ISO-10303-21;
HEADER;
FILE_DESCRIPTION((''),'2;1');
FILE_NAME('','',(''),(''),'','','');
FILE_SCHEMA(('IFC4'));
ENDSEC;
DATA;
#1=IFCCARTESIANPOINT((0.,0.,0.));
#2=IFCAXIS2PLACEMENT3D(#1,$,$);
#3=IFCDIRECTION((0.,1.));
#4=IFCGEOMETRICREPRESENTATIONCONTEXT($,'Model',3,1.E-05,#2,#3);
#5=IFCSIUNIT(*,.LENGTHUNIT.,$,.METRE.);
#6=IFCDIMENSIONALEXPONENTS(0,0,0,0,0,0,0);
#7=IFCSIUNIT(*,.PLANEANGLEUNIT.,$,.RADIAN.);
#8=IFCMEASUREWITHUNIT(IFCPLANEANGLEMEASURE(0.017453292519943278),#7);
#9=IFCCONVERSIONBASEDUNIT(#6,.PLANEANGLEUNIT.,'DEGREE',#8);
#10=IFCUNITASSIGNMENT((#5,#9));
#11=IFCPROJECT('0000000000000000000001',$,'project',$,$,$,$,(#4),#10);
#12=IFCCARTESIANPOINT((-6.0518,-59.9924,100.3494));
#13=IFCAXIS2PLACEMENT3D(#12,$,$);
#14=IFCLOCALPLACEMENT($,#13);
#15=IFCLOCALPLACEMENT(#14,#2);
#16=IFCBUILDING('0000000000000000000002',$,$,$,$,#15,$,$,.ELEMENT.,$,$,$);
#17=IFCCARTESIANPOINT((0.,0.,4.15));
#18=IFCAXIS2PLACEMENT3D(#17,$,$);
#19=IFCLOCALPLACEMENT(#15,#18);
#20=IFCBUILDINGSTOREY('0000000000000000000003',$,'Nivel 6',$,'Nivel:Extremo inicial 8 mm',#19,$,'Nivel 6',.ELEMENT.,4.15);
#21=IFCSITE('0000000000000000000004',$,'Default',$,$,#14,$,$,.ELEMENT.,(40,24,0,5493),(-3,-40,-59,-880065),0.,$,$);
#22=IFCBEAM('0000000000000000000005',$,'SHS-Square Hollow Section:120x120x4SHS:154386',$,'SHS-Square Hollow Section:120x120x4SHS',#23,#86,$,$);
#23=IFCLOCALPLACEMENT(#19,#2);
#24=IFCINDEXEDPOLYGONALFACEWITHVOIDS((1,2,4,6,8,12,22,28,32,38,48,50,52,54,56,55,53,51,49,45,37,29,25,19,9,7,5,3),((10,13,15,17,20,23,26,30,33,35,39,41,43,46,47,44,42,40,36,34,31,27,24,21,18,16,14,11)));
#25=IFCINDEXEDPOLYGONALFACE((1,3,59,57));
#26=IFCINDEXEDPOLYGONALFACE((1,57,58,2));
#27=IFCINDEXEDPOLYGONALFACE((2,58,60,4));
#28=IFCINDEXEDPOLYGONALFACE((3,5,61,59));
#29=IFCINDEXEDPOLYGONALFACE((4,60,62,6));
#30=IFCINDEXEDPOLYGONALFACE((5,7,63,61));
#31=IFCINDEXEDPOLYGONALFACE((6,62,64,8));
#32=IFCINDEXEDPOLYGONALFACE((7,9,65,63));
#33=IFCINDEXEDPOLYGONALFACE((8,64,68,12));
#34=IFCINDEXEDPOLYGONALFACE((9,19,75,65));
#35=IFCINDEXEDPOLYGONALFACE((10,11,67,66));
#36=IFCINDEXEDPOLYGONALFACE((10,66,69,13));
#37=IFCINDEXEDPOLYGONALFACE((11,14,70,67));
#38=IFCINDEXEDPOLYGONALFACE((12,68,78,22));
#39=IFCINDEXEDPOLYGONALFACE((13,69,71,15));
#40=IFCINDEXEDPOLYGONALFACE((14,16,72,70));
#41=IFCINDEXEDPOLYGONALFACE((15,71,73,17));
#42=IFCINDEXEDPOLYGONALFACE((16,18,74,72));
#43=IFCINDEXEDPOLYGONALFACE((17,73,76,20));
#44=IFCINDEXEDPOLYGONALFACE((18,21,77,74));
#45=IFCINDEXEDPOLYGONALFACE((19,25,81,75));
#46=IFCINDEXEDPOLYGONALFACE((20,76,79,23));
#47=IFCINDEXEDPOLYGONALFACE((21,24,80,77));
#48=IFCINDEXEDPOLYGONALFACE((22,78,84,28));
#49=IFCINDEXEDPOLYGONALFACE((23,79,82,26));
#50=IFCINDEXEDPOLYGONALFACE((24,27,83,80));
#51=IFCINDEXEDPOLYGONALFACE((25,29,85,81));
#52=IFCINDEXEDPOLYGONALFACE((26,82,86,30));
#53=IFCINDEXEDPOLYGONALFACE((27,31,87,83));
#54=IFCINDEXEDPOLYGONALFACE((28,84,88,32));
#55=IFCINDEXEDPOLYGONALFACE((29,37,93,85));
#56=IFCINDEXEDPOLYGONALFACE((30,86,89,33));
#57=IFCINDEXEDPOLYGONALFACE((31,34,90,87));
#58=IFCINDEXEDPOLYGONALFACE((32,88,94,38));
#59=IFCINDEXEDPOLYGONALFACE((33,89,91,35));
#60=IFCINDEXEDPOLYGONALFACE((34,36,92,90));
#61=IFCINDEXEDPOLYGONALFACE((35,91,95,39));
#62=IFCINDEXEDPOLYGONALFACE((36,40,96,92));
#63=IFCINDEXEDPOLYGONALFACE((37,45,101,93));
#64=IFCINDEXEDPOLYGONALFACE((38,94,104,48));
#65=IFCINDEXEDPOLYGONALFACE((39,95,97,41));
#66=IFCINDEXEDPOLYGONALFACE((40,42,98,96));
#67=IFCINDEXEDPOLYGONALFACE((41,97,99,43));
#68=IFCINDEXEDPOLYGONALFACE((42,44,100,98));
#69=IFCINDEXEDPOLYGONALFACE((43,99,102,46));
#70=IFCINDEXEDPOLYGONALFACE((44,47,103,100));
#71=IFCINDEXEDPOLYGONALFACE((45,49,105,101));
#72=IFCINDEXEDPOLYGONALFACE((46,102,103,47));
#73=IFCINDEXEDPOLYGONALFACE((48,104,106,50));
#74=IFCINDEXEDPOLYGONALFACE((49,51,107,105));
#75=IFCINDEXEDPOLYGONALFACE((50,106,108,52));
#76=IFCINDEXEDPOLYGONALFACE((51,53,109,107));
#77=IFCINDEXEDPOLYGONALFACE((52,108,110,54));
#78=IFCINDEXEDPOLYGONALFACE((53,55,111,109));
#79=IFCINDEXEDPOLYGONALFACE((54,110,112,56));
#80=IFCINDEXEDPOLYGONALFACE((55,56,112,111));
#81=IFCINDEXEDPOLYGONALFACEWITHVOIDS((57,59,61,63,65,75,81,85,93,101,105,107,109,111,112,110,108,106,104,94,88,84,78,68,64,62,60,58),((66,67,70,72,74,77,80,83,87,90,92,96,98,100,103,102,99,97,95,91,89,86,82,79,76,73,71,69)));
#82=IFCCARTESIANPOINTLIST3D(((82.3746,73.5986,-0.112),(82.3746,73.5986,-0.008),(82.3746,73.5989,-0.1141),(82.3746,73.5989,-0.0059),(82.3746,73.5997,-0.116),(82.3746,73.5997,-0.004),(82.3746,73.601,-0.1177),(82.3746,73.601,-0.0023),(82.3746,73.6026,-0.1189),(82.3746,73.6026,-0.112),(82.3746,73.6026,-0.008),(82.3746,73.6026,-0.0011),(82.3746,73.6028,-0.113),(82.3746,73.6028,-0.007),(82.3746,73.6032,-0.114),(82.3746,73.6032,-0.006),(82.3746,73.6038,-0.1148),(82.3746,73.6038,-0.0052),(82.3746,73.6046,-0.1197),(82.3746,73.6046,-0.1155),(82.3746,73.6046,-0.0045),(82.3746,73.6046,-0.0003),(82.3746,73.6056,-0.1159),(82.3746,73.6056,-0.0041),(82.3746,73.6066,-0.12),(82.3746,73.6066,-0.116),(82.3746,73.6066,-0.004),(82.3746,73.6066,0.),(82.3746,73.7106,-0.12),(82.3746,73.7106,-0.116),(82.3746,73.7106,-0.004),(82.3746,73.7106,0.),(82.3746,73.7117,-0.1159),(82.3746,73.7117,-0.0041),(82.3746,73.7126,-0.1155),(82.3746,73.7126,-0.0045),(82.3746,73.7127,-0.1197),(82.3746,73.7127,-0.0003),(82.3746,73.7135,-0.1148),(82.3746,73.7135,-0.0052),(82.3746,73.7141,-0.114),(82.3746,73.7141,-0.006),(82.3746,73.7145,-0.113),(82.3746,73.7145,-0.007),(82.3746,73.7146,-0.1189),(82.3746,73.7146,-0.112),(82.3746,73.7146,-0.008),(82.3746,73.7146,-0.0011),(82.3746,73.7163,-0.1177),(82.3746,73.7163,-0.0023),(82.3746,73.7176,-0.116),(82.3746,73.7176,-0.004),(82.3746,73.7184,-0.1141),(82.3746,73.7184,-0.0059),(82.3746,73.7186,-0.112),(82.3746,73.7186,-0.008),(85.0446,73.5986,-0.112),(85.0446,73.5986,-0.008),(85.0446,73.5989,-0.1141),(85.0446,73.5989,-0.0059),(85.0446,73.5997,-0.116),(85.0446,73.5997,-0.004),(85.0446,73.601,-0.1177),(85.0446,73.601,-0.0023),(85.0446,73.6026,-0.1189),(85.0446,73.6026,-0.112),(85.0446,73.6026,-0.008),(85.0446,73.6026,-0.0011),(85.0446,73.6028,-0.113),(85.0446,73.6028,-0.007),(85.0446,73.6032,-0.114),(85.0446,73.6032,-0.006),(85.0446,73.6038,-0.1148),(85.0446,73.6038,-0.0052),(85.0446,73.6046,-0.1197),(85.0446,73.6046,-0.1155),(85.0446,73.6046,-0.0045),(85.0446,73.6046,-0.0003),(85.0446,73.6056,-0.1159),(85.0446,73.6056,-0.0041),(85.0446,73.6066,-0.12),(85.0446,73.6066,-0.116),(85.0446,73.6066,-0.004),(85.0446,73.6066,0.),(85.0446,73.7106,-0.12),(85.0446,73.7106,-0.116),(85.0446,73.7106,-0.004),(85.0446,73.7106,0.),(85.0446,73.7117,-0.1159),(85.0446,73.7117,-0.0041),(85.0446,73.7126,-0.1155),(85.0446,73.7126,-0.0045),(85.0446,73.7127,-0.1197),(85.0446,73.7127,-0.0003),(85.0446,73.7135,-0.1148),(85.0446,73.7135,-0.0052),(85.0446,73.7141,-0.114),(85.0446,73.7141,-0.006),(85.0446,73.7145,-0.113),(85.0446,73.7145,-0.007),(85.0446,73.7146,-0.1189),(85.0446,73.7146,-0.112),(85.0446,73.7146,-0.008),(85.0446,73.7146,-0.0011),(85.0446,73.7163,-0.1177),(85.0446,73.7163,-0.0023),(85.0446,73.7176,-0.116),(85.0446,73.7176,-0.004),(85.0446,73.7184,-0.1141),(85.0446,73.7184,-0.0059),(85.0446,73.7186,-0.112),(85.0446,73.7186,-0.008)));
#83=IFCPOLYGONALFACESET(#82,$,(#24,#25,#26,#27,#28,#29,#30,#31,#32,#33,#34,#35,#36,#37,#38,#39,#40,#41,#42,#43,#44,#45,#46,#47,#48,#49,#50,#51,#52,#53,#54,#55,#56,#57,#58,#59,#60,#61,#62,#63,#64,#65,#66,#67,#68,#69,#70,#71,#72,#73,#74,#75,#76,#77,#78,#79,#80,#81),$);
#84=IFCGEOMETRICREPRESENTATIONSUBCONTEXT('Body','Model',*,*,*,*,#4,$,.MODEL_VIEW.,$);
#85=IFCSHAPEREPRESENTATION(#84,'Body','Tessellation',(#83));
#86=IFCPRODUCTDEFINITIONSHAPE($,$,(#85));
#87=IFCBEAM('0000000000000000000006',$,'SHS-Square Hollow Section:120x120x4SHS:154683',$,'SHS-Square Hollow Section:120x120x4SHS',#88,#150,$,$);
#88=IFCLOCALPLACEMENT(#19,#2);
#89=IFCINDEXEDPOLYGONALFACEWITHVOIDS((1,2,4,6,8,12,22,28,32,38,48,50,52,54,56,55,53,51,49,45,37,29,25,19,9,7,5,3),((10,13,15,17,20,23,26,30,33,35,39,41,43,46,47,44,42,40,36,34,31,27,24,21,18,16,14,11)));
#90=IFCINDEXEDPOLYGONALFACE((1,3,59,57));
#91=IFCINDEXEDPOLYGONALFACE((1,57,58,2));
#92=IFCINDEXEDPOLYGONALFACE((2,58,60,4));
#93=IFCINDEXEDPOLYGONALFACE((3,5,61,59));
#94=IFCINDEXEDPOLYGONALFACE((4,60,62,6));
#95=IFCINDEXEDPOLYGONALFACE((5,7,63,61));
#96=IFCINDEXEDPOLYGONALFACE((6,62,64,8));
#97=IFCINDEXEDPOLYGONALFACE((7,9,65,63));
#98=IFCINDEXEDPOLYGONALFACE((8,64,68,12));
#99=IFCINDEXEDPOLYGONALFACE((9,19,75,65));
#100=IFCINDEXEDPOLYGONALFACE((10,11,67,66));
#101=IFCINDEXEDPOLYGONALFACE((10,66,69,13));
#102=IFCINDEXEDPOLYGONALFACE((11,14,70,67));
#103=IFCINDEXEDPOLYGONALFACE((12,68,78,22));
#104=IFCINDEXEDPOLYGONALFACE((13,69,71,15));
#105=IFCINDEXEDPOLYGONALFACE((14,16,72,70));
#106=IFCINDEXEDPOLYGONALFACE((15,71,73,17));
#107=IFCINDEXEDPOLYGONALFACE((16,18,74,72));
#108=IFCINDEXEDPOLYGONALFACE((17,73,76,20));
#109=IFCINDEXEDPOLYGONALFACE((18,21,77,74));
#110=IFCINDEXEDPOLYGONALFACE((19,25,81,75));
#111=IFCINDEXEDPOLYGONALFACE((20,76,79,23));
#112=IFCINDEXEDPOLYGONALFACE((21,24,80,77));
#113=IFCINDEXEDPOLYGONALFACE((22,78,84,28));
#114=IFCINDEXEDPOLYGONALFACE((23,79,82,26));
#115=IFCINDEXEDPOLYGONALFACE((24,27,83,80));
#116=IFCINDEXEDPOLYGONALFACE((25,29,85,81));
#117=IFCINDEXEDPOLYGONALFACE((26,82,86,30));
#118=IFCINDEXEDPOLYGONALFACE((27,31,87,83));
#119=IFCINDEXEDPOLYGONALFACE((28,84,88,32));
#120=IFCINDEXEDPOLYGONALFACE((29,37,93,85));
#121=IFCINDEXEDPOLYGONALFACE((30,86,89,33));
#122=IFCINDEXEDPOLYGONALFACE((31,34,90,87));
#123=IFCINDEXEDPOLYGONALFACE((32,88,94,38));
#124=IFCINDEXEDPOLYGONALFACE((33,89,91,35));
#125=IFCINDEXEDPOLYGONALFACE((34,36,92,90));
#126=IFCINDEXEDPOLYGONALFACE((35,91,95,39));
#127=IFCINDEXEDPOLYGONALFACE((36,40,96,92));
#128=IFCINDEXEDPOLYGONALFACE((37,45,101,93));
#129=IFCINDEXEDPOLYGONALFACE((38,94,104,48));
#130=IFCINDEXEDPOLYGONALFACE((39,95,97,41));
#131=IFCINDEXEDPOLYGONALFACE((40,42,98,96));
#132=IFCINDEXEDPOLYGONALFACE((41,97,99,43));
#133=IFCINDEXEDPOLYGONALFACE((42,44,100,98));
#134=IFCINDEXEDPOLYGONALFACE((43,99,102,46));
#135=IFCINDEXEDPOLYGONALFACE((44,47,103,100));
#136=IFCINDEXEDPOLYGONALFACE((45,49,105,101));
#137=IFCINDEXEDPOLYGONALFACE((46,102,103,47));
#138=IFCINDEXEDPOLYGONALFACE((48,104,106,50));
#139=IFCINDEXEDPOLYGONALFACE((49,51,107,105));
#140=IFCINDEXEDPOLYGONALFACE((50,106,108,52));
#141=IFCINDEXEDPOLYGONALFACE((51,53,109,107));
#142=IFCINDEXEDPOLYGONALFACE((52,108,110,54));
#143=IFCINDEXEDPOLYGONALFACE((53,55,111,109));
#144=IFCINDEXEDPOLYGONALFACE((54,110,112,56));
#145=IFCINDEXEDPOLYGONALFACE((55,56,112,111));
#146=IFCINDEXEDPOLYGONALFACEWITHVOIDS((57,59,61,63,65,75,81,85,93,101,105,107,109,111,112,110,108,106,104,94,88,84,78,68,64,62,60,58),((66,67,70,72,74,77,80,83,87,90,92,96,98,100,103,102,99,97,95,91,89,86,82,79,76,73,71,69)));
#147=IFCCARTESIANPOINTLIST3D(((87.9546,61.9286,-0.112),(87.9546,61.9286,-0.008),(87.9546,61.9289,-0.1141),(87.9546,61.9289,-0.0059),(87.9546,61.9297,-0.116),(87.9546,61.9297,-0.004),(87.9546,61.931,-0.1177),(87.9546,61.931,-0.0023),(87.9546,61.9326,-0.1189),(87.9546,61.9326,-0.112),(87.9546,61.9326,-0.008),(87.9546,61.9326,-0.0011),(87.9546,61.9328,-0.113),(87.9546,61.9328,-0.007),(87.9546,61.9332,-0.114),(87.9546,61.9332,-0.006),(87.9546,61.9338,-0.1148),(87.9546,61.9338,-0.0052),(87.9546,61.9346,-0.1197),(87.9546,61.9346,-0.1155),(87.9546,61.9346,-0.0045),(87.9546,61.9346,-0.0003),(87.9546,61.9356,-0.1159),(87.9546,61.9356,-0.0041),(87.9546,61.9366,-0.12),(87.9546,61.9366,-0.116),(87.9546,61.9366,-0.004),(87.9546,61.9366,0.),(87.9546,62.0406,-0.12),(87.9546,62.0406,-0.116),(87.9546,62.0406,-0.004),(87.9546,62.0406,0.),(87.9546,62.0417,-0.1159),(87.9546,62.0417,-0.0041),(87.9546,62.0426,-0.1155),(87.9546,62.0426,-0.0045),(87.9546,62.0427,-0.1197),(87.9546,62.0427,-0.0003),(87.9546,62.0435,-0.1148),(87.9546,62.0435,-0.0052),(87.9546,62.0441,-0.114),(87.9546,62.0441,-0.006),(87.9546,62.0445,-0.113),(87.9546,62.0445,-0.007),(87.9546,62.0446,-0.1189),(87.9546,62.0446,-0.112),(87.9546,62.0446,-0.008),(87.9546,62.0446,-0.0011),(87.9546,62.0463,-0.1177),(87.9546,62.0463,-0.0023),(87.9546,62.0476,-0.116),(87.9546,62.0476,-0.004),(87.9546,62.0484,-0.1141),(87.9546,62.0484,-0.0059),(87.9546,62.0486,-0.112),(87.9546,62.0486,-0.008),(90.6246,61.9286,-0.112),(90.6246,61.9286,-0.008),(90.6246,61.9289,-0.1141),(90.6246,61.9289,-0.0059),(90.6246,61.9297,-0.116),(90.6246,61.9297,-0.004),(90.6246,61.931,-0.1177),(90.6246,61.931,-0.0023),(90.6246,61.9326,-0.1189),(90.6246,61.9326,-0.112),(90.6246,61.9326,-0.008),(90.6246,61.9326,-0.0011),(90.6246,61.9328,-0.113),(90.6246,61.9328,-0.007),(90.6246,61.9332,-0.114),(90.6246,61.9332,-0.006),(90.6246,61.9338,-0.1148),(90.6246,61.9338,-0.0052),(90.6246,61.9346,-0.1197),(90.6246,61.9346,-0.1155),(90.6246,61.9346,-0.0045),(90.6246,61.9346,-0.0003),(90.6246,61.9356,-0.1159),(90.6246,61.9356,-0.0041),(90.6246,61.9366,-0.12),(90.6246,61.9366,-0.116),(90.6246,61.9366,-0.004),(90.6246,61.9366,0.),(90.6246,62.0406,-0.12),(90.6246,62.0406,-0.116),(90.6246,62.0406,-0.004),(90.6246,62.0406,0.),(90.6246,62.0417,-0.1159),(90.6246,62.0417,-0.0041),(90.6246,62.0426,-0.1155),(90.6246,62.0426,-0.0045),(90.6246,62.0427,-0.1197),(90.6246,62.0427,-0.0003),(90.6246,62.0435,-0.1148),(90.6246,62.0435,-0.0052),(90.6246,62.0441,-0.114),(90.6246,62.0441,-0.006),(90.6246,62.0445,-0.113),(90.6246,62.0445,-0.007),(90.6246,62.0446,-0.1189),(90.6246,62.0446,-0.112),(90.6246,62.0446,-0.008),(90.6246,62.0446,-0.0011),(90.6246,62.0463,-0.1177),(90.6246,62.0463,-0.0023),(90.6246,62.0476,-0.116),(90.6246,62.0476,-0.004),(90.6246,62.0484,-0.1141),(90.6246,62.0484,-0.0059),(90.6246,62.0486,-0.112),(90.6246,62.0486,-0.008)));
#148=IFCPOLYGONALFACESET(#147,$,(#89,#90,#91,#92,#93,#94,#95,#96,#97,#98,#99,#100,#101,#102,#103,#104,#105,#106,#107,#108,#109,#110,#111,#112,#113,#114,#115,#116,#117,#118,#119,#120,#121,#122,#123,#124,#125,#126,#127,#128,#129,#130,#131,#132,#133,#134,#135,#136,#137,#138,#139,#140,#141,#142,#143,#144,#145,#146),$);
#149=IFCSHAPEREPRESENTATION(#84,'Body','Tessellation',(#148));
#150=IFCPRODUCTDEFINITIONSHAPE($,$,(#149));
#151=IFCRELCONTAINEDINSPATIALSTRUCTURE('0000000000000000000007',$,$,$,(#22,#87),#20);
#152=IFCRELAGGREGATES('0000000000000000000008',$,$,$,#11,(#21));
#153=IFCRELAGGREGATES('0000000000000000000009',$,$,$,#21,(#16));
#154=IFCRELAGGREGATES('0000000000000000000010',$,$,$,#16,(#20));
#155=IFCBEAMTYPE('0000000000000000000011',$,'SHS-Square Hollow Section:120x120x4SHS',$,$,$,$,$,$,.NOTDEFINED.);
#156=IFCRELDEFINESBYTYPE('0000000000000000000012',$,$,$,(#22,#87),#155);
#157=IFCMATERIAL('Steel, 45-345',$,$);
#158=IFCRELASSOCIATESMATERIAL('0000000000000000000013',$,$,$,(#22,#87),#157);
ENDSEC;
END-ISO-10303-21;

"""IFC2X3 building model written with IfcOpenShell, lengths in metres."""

from ifc_helpers import new_model, entity, si_unit, converted_unit, direction, frame, frame_2d, origin, place, context, subcontext, project, spatial, polyline, circle_curve, parameter, trimmed, segment, composite_curve, outline, extrude, material, type_object, element, save


model = new_model("IFC2X3")

# Units and contexts
model_context = context("Model", 3, precision=1e-05, world=origin(), true_north=direction((0.0, 1.0)))
body_context = subcontext(model_context, "Body", "Model", "MODEL_VIEW")
ifc_project = project(units=[si_unit("LENGTHUNIT", "METRE"), converted_unit("PLANEANGLEUNIT", "DEGREE", entity("IfcPlaneAngleMeasure", 0.017453292519943278), si_unit("PLANEANGLEUNIT", "RADIAN"), dimensions=[0, 0, 0, 0, 0, 0, 0])], contexts=[model_context])

# Site, building, storey
site_placement = place(None, frame((-6.0518, -59.9924, 100.3494)))
site = spatial("IfcSite", under=ifc_project, at=site_placement, Name="Default", CompositionType="ELEMENT", RefLatitude=(40, 24, 0, 5493), RefLongitude=(-3, -40, -59, -880065), RefElevation=0.0)
building_placement = place(site_placement, origin())
building = spatial("IfcBuilding", under=site, at=building_placement, CompositionType="ELEMENT")
storey_placement = place(building_placement, frame((0.0, 0.0, 4.15)))
storey = spatial("IfcBuildingStorey", under=building, at=storey_placement, Name="Nivel 6", ObjectType="Nivel:Extremo inicial 8 mm", LongName="Nivel 6", CompositionType="ELEMENT", Elevation=4.15)

# Beams
ifc_material_1 = material(Name="Steel, 45-345")
beam_type = type_object("IfcBeamType", Name="SHS-Square Hollow Section:120x120x4SHS", PredefinedType="NOTDEFINED")
beam_1_placement = place(storey_placement, frame((85.1046, 73.6586, 0.0), z_axis=(0.0, 0.0, 1.0), x_axis=(-1.0, 0.0, 0.0)))
element("IfcBeam", 1, at=beam_1_placement, inside=storey, type_object=beam_type, material=ifc_material_1, Name="SHS-Square Hollow Section:120x120x4SHS:154386", ObjectType="SHS-Square Hollow Section:120x120x4SHS", context=body_context, shape_type="SweptSolid", body=[
    extrude(outline(composite_curve([segment(trimmed(circle_curve(frame_2d((-0.052, -0.052), x_axis=(1.0, 0.0)), 0.008), [parameter(180.0)], [parameter(270.0)], True, "PARAMETER"), True, "CONTINUOUS"), segment(polyline([(-0.052, -0.06), (0.052, -0.06)]), True, "CONTINUOUS"), segment(trimmed(circle_curve(frame_2d((0.052, -0.052), x_axis=(1.0, 0.0)), 0.008), [parameter(270.0)], [parameter(0.0)], True, "PARAMETER"), True, "CONTINUOUS"), segment(polyline([(0.06, -0.052), (0.06, 0.052)]), True, "CONTINUOUS"), segment(trimmed(circle_curve(frame_2d((0.052, 0.052), x_axis=(1.0, 0.0)), 0.008), [parameter(360.0)], [parameter(90.0)], True, "PARAMETER"), True, "CONTINUOUS"), segment(polyline([(0.052, 0.06), (-0.052, 0.06)]), True, "CONTINUOUS"), segment(trimmed(circle_curve(frame_2d((-0.052, 0.052), x_axis=(1.0, 0.0)), 0.008), [parameter(90.0)], [parameter(180.0)], True, "PARAMETER"), True, "CONTINUOUS"), segment(polyline([(-0.06, 0.052), (-0.06, -0.052)]), True, "CONTINUOUS")], self_intersect=False), holes=[composite_curve([segment(polyline([(0.052, -0.056), (-0.052, -0.056)]), True, "CONTINUOUS"), segment(trimmed(circle_curve(frame_2d((-0.052, -0.052), x_axis=(1.0, 0.0)), 0.004), [parameter(180.0)], [parameter(270.0)], True, "PARAMETER"), False, "CONTINUOUS"), segment(polyline([(-0.056, -0.052), (-0.056, 0.052)]), True, "CONTINUOUS"), segment(trimmed(circle_curve(frame_2d((-0.052, 0.052), x_axis=(1.0, 0.0)), 0.004), [parameter(90.0)], [parameter(180.0)], True, "PARAMETER"), False, "CONTINUOUS"), segment(polyline([(-0.052, 0.056), (0.052, 0.056)]), True, "CONTINUOUS"), segment(trimmed(circle_curve(frame_2d((0.052, 0.052), x_axis=(1.0, 0.0)), 0.004), [parameter(0.0)], [parameter(90.0)], True, "PARAMETER"), False, "CONTINUOUS"), segment(polyline([(0.056, 0.052), (0.056, -0.052)]), True, "CONTINUOUS"), segment(trimmed(circle_curve(frame_2d((0.052, -0.052), x_axis=(1.0, 0.0)), 0.004), [parameter(270.0)], [parameter(0.0)], True, "PARAMETER"), False, "CONTINUOUS")], self_intersect=False)]), frame((0.06, 0.0, -0.06), z_axis=(1.0, 0.0, 0.0), x_axis=(0.0, -1.0, 0.0)), (0.0, 0.0, 1.0), 2.67),
])
beam_2_placement = place(storey_placement, frame((90.6846, 61.9886, 0.0), z_axis=(0.0, 0.0, 1.0), x_axis=(-1.0, 0.0, 0.0)))
element("IfcBeam", 2, at=beam_2_placement, inside=storey, type_object=beam_type, material=ifc_material_1, Name="SHS-Square Hollow Section:120x120x4SHS:154683", ObjectType="SHS-Square Hollow Section:120x120x4SHS", context=body_context, shape_type="SweptSolid", body=[
    extrude(outline(composite_curve([segment(trimmed(circle_curve(frame_2d((-0.052, -0.052), x_axis=(1.0, 0.0)), 0.008), [parameter(180.0)], [parameter(270.0)], True, "PARAMETER"), True, "CONTINUOUS"), segment(polyline([(-0.052, -0.06), (0.052, -0.06)]), True, "CONTINUOUS"), segment(trimmed(circle_curve(frame_2d((0.052, -0.052), x_axis=(1.0, 0.0)), 0.008), [parameter(270.0)], [parameter(0.0)], True, "PARAMETER"), True, "CONTINUOUS"), segment(polyline([(0.06, -0.052), (0.06, 0.052)]), True, "CONTINUOUS"), segment(trimmed(circle_curve(frame_2d((0.052, 0.052), x_axis=(1.0, 0.0)), 0.008), [parameter(360.0)], [parameter(90.0)], True, "PARAMETER"), True, "CONTINUOUS"), segment(polyline([(0.052, 0.06), (-0.052, 0.06)]), True, "CONTINUOUS"), segment(trimmed(circle_curve(frame_2d((-0.052, 0.052), x_axis=(1.0, 0.0)), 0.008), [parameter(90.0)], [parameter(180.0)], True, "PARAMETER"), True, "CONTINUOUS"), segment(polyline([(-0.06, 0.052), (-0.06, -0.052)]), True, "CONTINUOUS")], self_intersect=False), holes=[composite_curve([segment(polyline([(0.052, -0.056), (-0.052, -0.056)]), True, "CONTINUOUS"), segment(trimmed(circle_curve(frame_2d((-0.052, -0.052), x_axis=(1.0, 0.0)), 0.004), [parameter(180.0)], [parameter(270.0)], True, "PARAMETER"), False, "CONTINUOUS"), segment(polyline([(-0.056, -0.052), (-0.056, 0.052)]), True, "CONTINUOUS"), segment(trimmed(circle_curve(frame_2d((-0.052, 0.052), x_axis=(1.0, 0.0)), 0.004), [parameter(90.0)], [parameter(180.0)], True, "PARAMETER"), False, "CONTINUOUS"), segment(polyline([(-0.052, 0.056), (0.052, 0.056)]), True, "CONTINUOUS"), segment(trimmed(circle_curve(frame_2d((0.052, 0.052), x_axis=(1.0, 0.0)), 0.004), [parameter(0.0)], [parameter(90.0)], True, "PARAMETER"), False, "CONTINUOUS"), segment(polyline([(0.056, 0.052), (0.056, -0.052)]), True, "CONTINUOUS"), segment(trimmed(circle_curve(frame_2d((0.052, -0.052), x_axis=(1.0, 0.0)), 0.004), [parameter(270.0)], [parameter(0.0)], True, "PARAMETER"), False, "CONTINUOUS")], self_intersect=False)]), frame((0.06, 0.0, -0.06), z_axis=(1.0, 0.0, 0.0), x_axis=(0.0, -1.0, 0.0)), (0.0, 0.0, 1.0), 2.67),
])

save(model, "model.ifc")
